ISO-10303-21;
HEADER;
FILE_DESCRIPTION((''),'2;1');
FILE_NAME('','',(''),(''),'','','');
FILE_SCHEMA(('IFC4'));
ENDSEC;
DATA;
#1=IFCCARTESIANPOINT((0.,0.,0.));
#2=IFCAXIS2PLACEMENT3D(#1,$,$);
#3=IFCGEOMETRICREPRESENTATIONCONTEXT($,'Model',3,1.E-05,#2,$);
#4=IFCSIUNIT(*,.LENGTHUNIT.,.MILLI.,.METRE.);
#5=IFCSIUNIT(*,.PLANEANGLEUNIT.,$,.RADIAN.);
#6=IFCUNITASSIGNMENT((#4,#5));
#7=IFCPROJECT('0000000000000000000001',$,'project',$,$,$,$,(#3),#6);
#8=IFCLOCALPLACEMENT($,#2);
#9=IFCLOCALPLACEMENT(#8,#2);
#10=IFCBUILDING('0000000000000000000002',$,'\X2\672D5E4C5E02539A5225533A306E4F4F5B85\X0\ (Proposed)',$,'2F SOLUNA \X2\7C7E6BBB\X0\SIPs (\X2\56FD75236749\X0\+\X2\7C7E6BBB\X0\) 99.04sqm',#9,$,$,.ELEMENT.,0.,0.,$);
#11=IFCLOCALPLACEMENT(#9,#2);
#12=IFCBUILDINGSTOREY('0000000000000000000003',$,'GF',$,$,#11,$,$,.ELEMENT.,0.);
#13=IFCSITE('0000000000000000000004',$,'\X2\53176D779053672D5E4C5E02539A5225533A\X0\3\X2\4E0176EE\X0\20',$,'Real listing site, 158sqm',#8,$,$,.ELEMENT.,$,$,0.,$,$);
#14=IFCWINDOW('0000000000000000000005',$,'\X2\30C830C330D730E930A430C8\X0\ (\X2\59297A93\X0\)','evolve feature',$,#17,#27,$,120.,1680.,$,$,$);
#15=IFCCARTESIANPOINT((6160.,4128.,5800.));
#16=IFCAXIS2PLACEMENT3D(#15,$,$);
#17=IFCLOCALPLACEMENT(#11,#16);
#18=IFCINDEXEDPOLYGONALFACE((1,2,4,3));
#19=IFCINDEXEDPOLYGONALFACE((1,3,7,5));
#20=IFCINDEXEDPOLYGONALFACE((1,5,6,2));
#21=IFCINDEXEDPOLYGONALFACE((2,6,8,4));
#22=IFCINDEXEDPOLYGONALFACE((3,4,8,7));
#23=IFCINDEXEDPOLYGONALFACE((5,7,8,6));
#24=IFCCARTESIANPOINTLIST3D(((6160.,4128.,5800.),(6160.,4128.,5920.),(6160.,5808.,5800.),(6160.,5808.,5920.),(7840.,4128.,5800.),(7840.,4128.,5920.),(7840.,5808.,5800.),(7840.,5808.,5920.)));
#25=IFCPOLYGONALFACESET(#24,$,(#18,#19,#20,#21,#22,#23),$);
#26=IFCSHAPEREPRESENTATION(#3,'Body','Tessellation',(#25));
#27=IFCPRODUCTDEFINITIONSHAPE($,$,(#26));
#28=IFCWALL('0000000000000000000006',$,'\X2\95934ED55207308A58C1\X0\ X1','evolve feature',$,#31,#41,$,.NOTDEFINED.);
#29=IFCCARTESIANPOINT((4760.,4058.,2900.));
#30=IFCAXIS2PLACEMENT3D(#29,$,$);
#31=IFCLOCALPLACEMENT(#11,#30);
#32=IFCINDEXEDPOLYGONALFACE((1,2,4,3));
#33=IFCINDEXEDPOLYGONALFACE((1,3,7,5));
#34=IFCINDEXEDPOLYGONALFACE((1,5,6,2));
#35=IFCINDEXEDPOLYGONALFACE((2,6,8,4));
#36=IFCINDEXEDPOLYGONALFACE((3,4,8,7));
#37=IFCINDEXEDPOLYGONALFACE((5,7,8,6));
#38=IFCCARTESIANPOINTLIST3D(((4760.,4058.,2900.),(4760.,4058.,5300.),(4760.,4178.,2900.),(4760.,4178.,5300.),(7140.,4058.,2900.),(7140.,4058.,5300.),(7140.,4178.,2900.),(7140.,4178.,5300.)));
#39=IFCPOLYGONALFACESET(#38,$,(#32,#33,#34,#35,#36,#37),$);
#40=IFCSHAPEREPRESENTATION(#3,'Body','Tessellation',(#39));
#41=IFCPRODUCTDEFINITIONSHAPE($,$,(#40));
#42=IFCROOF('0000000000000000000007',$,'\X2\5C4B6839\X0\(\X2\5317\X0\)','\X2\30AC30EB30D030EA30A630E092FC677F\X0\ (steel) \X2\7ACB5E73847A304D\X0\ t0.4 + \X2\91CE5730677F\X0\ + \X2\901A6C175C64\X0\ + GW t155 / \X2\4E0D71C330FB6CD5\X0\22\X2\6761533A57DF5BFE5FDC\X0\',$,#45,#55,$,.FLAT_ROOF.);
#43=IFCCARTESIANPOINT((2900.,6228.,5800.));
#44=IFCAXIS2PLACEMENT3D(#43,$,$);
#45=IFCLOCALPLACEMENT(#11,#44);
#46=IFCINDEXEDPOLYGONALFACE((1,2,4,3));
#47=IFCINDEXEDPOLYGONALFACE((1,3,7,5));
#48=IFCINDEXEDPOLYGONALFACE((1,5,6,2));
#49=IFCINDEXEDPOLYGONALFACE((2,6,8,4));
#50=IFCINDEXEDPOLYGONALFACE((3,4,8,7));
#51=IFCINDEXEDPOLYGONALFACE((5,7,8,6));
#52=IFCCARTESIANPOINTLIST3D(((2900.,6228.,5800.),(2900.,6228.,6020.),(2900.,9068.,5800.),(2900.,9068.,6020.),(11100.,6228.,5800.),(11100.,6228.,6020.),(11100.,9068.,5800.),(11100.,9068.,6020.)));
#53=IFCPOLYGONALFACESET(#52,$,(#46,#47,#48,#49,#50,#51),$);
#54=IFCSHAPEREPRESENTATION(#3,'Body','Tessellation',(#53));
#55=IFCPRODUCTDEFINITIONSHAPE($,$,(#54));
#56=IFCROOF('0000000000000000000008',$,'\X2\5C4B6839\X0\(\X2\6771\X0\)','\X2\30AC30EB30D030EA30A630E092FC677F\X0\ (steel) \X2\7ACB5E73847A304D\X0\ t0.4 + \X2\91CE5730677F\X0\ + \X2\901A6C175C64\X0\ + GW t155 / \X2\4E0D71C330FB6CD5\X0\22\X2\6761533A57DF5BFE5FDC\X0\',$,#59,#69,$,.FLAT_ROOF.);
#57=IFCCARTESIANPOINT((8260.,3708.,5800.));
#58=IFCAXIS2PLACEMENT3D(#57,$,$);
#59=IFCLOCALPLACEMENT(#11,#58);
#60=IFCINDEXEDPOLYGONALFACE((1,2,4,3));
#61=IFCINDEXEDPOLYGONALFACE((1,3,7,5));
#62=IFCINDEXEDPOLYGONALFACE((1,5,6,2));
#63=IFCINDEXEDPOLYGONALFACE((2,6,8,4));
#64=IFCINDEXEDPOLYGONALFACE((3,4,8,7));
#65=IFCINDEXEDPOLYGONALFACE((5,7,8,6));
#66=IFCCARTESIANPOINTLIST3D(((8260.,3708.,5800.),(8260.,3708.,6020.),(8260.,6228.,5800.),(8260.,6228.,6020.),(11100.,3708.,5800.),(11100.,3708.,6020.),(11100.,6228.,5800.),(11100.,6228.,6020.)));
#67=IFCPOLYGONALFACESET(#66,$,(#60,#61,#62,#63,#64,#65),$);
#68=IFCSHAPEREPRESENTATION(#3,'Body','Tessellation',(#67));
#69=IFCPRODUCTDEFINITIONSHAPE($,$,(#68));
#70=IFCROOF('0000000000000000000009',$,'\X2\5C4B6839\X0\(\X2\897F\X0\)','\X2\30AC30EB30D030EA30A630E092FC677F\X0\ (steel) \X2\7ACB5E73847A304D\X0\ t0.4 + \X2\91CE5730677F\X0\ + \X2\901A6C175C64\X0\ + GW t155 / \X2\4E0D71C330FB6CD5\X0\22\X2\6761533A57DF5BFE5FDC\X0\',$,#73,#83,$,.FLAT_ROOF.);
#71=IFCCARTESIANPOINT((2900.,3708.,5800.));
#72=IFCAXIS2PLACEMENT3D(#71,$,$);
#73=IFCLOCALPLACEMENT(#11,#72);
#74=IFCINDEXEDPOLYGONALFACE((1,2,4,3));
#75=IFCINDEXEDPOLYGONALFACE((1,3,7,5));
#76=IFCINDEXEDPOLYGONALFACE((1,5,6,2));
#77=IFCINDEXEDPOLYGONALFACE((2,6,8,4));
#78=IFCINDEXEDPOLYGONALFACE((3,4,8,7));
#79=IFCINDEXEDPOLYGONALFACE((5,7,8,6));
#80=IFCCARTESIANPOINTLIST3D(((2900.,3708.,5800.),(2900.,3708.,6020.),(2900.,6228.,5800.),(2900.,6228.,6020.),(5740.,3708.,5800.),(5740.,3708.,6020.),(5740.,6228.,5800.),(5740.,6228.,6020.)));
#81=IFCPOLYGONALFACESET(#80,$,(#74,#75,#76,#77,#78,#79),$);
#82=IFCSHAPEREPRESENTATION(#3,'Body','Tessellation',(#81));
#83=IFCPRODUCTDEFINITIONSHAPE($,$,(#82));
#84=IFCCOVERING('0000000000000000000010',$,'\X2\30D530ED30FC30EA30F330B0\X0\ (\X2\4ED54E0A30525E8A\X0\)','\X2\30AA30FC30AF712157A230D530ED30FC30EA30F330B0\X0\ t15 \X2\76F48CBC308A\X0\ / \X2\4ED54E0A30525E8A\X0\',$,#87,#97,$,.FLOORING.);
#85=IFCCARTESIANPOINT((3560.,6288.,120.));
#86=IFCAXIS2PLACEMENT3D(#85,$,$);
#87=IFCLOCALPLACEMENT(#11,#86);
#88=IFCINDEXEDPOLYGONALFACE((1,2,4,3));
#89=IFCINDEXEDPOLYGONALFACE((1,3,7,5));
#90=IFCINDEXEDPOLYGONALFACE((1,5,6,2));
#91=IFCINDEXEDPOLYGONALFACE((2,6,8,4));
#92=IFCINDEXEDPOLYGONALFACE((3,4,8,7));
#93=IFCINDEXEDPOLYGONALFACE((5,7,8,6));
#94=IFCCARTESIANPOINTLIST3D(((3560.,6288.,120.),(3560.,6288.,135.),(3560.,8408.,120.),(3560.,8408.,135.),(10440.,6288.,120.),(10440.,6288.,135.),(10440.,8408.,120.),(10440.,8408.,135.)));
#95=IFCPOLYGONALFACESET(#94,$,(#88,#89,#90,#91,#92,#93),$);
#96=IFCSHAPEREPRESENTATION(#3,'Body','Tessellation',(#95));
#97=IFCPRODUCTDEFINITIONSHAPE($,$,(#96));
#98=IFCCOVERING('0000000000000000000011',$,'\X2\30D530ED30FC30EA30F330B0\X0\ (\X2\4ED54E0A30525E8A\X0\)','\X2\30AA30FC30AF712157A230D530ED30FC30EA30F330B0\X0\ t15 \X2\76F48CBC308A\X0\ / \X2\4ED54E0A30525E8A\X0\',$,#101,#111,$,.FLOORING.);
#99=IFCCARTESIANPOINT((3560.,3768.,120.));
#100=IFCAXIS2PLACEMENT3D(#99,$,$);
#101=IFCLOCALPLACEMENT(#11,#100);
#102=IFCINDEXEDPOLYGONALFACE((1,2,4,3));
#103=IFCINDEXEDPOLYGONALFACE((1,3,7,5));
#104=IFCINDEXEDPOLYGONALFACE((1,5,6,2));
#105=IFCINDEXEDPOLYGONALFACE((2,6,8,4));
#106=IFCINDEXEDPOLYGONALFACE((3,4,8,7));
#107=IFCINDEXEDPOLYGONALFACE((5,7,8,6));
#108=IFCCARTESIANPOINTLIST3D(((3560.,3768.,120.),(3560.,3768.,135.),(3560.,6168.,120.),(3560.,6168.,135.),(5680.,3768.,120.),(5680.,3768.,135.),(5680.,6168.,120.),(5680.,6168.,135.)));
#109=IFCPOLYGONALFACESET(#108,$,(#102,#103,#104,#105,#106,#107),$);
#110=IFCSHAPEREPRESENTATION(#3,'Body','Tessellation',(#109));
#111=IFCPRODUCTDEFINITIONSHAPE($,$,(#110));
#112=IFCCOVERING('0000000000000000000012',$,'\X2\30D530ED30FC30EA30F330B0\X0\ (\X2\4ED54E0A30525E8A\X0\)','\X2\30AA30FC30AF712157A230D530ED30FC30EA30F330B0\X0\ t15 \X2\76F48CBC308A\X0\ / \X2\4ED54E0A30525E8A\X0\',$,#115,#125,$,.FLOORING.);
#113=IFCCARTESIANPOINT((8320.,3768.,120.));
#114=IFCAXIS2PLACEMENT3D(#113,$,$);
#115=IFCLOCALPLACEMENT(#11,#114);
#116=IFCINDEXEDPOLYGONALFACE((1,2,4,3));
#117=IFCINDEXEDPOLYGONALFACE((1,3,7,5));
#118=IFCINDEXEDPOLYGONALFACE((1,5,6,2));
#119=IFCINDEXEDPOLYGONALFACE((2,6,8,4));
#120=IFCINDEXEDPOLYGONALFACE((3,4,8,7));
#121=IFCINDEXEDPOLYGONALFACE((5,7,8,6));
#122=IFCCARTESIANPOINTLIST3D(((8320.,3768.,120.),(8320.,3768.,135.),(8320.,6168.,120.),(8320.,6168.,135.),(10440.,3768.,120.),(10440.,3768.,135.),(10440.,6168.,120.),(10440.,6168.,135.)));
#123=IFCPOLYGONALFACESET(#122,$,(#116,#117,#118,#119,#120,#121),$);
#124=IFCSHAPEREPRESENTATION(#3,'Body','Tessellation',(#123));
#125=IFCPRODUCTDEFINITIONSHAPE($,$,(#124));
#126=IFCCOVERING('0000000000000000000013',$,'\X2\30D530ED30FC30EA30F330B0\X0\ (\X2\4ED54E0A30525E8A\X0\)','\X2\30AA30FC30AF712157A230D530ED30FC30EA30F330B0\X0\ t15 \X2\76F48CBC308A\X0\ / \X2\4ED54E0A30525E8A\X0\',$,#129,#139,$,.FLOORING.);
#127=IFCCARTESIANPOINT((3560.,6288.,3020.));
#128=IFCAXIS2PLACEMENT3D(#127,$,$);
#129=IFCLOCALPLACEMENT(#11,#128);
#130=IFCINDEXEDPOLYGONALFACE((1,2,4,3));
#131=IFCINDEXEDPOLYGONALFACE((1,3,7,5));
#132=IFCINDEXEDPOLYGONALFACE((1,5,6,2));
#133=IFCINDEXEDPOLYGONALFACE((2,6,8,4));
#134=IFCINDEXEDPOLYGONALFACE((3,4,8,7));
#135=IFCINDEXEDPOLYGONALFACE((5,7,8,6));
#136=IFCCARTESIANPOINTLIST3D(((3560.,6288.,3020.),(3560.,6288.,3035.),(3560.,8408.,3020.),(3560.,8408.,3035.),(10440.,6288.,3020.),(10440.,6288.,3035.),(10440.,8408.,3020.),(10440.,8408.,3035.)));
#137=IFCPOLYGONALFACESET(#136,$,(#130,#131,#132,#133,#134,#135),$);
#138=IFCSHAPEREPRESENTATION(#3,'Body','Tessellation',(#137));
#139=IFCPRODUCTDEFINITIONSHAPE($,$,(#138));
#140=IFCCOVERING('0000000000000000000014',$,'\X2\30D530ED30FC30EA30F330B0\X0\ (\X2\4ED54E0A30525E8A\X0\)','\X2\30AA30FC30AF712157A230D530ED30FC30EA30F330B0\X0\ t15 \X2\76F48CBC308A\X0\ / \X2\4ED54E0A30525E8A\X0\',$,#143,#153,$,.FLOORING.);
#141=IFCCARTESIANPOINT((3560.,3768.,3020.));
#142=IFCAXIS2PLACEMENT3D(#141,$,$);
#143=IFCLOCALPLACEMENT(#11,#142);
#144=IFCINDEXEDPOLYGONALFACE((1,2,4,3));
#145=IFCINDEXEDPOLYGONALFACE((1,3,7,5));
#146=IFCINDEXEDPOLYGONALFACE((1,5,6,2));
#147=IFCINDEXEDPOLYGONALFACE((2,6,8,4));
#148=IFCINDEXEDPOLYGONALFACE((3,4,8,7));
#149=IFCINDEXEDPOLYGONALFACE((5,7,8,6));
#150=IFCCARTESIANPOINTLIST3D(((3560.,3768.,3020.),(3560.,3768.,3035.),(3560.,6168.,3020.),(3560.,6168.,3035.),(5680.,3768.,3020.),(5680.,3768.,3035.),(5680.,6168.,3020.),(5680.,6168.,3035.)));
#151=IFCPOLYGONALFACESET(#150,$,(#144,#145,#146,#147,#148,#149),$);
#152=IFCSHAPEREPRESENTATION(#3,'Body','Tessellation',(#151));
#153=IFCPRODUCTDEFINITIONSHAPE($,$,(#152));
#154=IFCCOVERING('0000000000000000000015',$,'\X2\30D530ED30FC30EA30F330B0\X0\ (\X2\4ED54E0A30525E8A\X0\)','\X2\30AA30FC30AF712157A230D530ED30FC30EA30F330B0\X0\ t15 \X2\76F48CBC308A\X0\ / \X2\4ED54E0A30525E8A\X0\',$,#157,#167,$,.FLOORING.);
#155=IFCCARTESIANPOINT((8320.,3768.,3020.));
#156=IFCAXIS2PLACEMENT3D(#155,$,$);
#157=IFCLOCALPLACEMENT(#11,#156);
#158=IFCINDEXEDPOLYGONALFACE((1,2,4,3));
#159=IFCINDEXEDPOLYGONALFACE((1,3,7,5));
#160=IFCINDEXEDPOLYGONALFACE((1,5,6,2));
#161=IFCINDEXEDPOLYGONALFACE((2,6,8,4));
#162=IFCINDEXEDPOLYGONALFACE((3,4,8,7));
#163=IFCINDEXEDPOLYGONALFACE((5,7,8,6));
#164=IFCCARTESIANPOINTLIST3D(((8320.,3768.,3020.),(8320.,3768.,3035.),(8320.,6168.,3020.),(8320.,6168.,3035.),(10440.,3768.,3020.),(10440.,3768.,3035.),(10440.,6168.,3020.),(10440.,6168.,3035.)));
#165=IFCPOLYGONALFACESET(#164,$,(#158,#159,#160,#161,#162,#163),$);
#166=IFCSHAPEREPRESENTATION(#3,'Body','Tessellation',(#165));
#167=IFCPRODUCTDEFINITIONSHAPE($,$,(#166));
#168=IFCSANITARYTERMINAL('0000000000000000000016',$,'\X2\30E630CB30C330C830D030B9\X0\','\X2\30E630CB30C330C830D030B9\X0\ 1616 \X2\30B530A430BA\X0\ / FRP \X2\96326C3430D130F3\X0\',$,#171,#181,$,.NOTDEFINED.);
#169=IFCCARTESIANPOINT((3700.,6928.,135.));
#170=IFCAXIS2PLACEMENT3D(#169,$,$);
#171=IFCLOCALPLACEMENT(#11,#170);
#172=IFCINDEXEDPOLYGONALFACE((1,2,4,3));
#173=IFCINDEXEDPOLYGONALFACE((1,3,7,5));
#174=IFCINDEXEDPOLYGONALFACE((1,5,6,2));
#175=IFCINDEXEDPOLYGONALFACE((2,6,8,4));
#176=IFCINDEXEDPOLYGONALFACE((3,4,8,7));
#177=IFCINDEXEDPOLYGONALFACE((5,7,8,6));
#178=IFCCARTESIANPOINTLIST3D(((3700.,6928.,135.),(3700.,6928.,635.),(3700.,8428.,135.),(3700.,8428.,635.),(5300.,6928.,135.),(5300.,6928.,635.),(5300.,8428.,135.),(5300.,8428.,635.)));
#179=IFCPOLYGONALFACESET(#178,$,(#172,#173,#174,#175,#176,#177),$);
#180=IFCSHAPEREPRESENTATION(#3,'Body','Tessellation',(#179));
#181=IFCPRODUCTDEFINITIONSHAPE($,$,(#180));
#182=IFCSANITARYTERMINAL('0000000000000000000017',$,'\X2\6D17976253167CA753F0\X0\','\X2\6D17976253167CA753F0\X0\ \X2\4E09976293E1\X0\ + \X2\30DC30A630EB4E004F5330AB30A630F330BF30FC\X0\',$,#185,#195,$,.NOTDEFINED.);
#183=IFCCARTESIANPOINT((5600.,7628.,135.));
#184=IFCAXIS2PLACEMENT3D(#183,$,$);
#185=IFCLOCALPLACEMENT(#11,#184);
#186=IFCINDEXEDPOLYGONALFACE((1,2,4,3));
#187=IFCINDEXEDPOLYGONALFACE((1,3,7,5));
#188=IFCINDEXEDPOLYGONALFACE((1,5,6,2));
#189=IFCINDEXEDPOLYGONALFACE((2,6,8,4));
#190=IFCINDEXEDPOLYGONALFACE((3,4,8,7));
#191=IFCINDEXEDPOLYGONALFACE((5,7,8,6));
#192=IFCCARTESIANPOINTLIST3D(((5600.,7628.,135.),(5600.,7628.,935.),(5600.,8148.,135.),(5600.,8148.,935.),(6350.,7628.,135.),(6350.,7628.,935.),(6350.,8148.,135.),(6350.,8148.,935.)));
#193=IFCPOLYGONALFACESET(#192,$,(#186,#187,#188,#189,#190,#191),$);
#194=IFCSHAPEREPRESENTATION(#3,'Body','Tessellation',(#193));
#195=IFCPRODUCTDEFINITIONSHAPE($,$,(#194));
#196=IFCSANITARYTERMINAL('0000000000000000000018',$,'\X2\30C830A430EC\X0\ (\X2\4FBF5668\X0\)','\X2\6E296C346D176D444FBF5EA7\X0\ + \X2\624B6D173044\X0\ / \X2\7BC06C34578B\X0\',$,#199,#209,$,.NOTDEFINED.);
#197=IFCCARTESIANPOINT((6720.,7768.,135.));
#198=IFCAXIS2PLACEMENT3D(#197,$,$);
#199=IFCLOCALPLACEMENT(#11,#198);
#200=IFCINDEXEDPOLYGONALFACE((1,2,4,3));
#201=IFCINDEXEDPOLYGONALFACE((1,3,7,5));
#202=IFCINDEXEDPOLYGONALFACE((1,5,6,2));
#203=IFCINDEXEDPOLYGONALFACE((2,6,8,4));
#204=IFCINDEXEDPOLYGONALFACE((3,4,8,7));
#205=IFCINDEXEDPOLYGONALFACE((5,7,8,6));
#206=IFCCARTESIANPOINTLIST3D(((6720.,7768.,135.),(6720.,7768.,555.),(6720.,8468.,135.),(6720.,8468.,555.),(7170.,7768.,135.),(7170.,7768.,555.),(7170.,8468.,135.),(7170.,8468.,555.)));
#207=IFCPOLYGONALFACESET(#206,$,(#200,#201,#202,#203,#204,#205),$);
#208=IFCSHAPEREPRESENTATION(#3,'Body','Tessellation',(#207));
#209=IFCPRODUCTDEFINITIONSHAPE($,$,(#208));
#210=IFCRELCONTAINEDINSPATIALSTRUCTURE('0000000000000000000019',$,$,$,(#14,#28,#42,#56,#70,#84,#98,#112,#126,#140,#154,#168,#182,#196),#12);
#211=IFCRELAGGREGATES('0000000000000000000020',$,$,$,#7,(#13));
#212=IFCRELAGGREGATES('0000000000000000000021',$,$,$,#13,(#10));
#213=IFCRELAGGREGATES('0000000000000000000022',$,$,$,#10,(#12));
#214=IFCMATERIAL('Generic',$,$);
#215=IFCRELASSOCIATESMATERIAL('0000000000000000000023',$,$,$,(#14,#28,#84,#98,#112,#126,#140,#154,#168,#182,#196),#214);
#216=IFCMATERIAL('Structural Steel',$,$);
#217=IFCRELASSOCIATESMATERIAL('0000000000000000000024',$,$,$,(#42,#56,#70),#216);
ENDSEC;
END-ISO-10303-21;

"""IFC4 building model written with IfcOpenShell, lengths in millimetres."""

from ifc_helpers import new_model, si_unit, frame, frame_2d, origin, place, context, project, spatial, rectangle, extrude, material, element, save


model = new_model("IFC4")

# Units and contexts
model_context = context("Model", 3, precision=1e-05, world=origin())
ifc_project = project(units=[si_unit("LENGTHUNIT", "METRE", prefix="MILLI"), si_unit("PLANEANGLEUNIT", "RADIAN")], contexts=[model_context])

# Site, building, storey
site_placement = place(None, origin())
site = spatial("IfcSite", under=ifc_project, at=site_placement, Name="北海道札幌市厚別区3丁目20", ObjectType="Real listing site, 158sqm", CompositionType="ELEMENT", RefElevation=0.0)
building_placement = place(site_placement, origin())
building = spatial("IfcBuilding", under=site, at=building_placement, Name="札幌市厚別区の住宅 (Proposed)", ObjectType="2F SOLUNA 籾殻SIPs (国産杉+籾殻) 99.04sqm", CompositionType="ELEMENT", ElevationOfRefHeight=0.0, ElevationOfTerrain=0.0)
storey_placement = place(building_placement, origin())
storey = spatial("IfcBuildingStorey", under=building, at=storey_placement, Name="GF", CompositionType="ELEMENT", Elevation=0.0)

# Window
ifc_material_1 = material(Name="Generic")
window_1_placement = place(storey_placement, frame((6160.0, 4128.0, 5800.0)))
element("IfcWindow", 1, at=window_1_placement, inside=storey, material=ifc_material_1, Name="トップライト (天窓)", Description="evolve feature", OverallHeight=120.0, OverallWidth=1680.0, context=model_context, shape_type="SweptSolid", body=[
    extrude(rectangle(XDim=1680.0, YDim=1680.0, at=frame_2d((840.0, 840.0))), frame((6160.0, 4128.0, 5800.0)), (0.0, 0.0, 1.0), 120.0),
])

# Wall
wall_1_placement = place(storey_placement, frame((4760.0, 4058.0, 2900.0)))
element("IfcWall", 2, at=wall_1_placement, inside=storey, material=ifc_material_1, Name="間仕切り壁 X1", Description="evolve feature", PredefinedType="NOTDEFINED", context=model_context, shape_type="SweptSolid", body=[
    extrude(rectangle(XDim=2380.0, YDim=120.0, at=frame_2d((1190.0, 60.0))), frame((4760.0, 4058.0, 2900.0)), (0.0, 0.0, 1.0), 2400.0),
])

# Roofs
ifc_material_2 = material(Name="Structural Steel")
roof_1_placement = place(storey_placement, frame((2900.0, 6228.0, 5800.0)))
element("IfcRoof", 3, at=roof_1_placement, inside=storey, material=ifc_material_2, Name="屋根(北)", Description="ガルバリウム鋼板 (steel) 立平葺き t0.4 + 野地板 + 通気層 + GW t155 / 不燃・法22条区域対応", PredefinedType="FLAT_ROOF", context=model_context, shape_type="SweptSolid", body=[
    extrude(rectangle(XDim=8200.0, YDim=2840.0, at=frame_2d((4100.0, 1420.0))), frame((2900.0, 6228.0, 5800.0)), (0.0, 0.0, 1.0), 220.0),
])
roof_2_placement = place(storey_placement, frame((8260.0, 3708.0, 5800.0)))
element("IfcRoof", 4, at=roof_2_placement, inside=storey, material=ifc_material_2, Name="屋根(東)", Description="ガルバリウム鋼板 (steel) 立平葺き t0.4 + 野地板 + 通気層 + GW t155 / 不燃・法22条区域対応", PredefinedType="FLAT_ROOF", context=model_context, shape_type="SweptSolid", body=[
    extrude(rectangle(XDim=2840.0, YDim=2520.0, at=frame_2d((1420.0, 1260.0))), frame((8260.0, 3708.0, 5800.0)), (0.0, 0.0, 1.0), 220.0),
])
roof_3_placement = place(storey_placement, frame((2900.0, 3708.0, 5800.0)))
element("IfcRoof", 5, at=roof_3_placement, inside=storey, material=ifc_material_2, Name="屋根(西)", Description="ガルバリウム鋼板 (steel) 立平葺き t0.4 + 野地板 + 通気層 + GW t155 / 不燃・法22条区域対応", PredefinedType="FLAT_ROOF", context=model_context, shape_type="SweptSolid", body=[
    extrude(rectangle(XDim=2840.0, YDim=2520.0, at=frame_2d((1420.0, 1260.0))), frame((2900.0, 3708.0, 5800.0)), (0.0, 0.0, 1.0), 220.0),
])

# Coverings
covering_1_placement = place(storey_placement, frame((3560.0, 6288.0, 120.0)))
element("IfcCovering", 6, at=covering_1_placement, inside=storey, material=ifc_material_1, Name="フローリング (仕上げ床)", Description="オーク無垢フローリング t15 直貼り / 仕上げ床", PredefinedType="FLOORING", context=model_context, shape_type="SweptSolid", body=[
    extrude(rectangle(XDim=6880.0, YDim=2120.0, at=frame_2d((3440.0, 1060.0))), frame((3560.0, 6288.0, 120.0)), (0.0, 0.0, 1.0), 15.0),
])
covering_2_placement = place(storey_placement, frame((3560.0, 3768.0, 120.0)))
element("IfcCovering", 7, at=covering_2_placement, inside=storey, material=ifc_material_1, Name="フローリング (仕上げ床)", Description="オーク無垢フローリング t15 直貼り / 仕上げ床", PredefinedType="FLOORING", context=model_context, shape_type="SweptSolid", body=[
    extrude(rectangle(XDim=2120.0, YDim=2400.0, at=frame_2d((1060.0, 1200.0))), frame((3560.0, 3768.0, 120.0)), (0.0, 0.0, 1.0), 15.0),
])
covering_3_placement = place(storey_placement, frame((8320.0, 3768.0, 120.0)))
element("IfcCovering", 8, at=covering_3_placement, inside=storey, material=ifc_material_1, Name="フローリング (仕上げ床)", Description="オーク無垢フローリング t15 直貼り / 仕上げ床", PredefinedType="FLOORING", context=model_context, shape_type="SweptSolid", body=[
    extrude(rectangle(XDim=2120.0, YDim=2400.0, at=frame_2d((1060.0, 1200.0))), frame((8320.0, 3768.0, 120.0)), (0.0, 0.0, 1.0), 15.0),
])
covering_4_placement = place(storey_placement, frame((3560.0, 6288.0, 3020.0)))
element("IfcCovering", 9, at=covering_4_placement, inside=storey, material=ifc_material_1, Name="フローリング (仕上げ床)", Description="オーク無垢フローリング t15 直貼り / 仕上げ床", PredefinedType="FLOORING", context=model_context, shape_type="SweptSolid", body=[
    extrude(rectangle(XDim=6880.0, YDim=2120.0, at=frame_2d((3440.0, 1060.0))), frame((3560.0, 6288.0, 3020.0)), (0.0, 0.0, 1.0), 15.0),
])
covering_5_placement = place(storey_placement, frame((3560.0, 3768.0, 3020.0)))
element("IfcCovering", 10, at=covering_5_placement, inside=storey, material=ifc_material_1, Name="フローリング (仕上げ床)", Description="オーク無垢フローリング t15 直貼り / 仕上げ床", PredefinedType="FLOORING", context=model_context, shape_type="SweptSolid", body=[
    extrude(rectangle(XDim=2120.0, YDim=2400.0, at=frame_2d((1060.0, 1200.0))), frame((3560.0, 3768.0, 3020.0)), (0.0, 0.0, 1.0), 15.0),
])
covering_6_placement = place(storey_placement, frame((8320.0, 3768.0, 3020.0)))
element("IfcCovering", 11, at=covering_6_placement, inside=storey, material=ifc_material_1, Name="フローリング (仕上げ床)", Description="オーク無垢フローリング t15 直貼り / 仕上げ床", PredefinedType="FLOORING", context=model_context, shape_type="SweptSolid", body=[
    extrude(rectangle(XDim=2120.0, YDim=2400.0, at=frame_2d((1060.0, 1200.0))), frame((8320.0, 3768.0, 3020.0)), (0.0, 0.0, 1.0), 15.0),
])

# Sanitary terminals
sanitary_terminal_1_placement = place(storey_placement, frame((3700.0, 6928.0, 135.0)))
element("IfcSanitaryTerminal", 12, at=sanitary_terminal_1_placement, inside=storey, material=ifc_material_1, Name="ユニットバス", Description="ユニットバス 1616 サイズ / FRP 防水パン", PredefinedType="NOTDEFINED", context=model_context, shape_type="SweptSolid", body=[
    extrude(rectangle(XDim=1600.0, YDim=1500.0, at=frame_2d((800.0, 750.0))), frame((3700.0, 6928.0, 135.0)), (0.0, 0.0, 1.0), 500.0),
])
sanitary_terminal_2_placement = place(storey_placement, frame((5600.0, 7628.0, 135.0)))
element("IfcSanitaryTerminal", 13, at=sanitary_terminal_2_placement, inside=storey, material=ifc_material_1, Name="洗面化粧台", Description="洗面化粧台 三面鏡 + ボウル一体カウンター", PredefinedType="NOTDEFINED", context=model_context, shape_type="SweptSolid", body=[
    extrude(rectangle(XDim=750.0, YDim=520.0, at=frame_2d((375.0, 260.0))), frame((5600.0, 7628.0, 135.0)), (0.0, 0.0, 1.0), 800.0),
])
sanitary_terminal_3_placement = place(storey_placement, frame((6720.0, 7768.0, 135.0)))
element("IfcSanitaryTerminal", 14, at=sanitary_terminal_3_placement, inside=storey, material=ifc_material_1, Name="トイレ (便器)", Description="温水洗浄便座 + 手洗い / 節水型", PredefinedType="NOTDEFINED", context=model_context, shape_type="SweptSolid", body=[
    extrude(rectangle(XDim=450.0, YDim=700.0, at=frame_2d((225.0, 350.0))), frame((6720.0, 7768.0, 135.0)), (0.0, 0.0, 1.0), 420.0),
])

save(model, "model.ifc")
